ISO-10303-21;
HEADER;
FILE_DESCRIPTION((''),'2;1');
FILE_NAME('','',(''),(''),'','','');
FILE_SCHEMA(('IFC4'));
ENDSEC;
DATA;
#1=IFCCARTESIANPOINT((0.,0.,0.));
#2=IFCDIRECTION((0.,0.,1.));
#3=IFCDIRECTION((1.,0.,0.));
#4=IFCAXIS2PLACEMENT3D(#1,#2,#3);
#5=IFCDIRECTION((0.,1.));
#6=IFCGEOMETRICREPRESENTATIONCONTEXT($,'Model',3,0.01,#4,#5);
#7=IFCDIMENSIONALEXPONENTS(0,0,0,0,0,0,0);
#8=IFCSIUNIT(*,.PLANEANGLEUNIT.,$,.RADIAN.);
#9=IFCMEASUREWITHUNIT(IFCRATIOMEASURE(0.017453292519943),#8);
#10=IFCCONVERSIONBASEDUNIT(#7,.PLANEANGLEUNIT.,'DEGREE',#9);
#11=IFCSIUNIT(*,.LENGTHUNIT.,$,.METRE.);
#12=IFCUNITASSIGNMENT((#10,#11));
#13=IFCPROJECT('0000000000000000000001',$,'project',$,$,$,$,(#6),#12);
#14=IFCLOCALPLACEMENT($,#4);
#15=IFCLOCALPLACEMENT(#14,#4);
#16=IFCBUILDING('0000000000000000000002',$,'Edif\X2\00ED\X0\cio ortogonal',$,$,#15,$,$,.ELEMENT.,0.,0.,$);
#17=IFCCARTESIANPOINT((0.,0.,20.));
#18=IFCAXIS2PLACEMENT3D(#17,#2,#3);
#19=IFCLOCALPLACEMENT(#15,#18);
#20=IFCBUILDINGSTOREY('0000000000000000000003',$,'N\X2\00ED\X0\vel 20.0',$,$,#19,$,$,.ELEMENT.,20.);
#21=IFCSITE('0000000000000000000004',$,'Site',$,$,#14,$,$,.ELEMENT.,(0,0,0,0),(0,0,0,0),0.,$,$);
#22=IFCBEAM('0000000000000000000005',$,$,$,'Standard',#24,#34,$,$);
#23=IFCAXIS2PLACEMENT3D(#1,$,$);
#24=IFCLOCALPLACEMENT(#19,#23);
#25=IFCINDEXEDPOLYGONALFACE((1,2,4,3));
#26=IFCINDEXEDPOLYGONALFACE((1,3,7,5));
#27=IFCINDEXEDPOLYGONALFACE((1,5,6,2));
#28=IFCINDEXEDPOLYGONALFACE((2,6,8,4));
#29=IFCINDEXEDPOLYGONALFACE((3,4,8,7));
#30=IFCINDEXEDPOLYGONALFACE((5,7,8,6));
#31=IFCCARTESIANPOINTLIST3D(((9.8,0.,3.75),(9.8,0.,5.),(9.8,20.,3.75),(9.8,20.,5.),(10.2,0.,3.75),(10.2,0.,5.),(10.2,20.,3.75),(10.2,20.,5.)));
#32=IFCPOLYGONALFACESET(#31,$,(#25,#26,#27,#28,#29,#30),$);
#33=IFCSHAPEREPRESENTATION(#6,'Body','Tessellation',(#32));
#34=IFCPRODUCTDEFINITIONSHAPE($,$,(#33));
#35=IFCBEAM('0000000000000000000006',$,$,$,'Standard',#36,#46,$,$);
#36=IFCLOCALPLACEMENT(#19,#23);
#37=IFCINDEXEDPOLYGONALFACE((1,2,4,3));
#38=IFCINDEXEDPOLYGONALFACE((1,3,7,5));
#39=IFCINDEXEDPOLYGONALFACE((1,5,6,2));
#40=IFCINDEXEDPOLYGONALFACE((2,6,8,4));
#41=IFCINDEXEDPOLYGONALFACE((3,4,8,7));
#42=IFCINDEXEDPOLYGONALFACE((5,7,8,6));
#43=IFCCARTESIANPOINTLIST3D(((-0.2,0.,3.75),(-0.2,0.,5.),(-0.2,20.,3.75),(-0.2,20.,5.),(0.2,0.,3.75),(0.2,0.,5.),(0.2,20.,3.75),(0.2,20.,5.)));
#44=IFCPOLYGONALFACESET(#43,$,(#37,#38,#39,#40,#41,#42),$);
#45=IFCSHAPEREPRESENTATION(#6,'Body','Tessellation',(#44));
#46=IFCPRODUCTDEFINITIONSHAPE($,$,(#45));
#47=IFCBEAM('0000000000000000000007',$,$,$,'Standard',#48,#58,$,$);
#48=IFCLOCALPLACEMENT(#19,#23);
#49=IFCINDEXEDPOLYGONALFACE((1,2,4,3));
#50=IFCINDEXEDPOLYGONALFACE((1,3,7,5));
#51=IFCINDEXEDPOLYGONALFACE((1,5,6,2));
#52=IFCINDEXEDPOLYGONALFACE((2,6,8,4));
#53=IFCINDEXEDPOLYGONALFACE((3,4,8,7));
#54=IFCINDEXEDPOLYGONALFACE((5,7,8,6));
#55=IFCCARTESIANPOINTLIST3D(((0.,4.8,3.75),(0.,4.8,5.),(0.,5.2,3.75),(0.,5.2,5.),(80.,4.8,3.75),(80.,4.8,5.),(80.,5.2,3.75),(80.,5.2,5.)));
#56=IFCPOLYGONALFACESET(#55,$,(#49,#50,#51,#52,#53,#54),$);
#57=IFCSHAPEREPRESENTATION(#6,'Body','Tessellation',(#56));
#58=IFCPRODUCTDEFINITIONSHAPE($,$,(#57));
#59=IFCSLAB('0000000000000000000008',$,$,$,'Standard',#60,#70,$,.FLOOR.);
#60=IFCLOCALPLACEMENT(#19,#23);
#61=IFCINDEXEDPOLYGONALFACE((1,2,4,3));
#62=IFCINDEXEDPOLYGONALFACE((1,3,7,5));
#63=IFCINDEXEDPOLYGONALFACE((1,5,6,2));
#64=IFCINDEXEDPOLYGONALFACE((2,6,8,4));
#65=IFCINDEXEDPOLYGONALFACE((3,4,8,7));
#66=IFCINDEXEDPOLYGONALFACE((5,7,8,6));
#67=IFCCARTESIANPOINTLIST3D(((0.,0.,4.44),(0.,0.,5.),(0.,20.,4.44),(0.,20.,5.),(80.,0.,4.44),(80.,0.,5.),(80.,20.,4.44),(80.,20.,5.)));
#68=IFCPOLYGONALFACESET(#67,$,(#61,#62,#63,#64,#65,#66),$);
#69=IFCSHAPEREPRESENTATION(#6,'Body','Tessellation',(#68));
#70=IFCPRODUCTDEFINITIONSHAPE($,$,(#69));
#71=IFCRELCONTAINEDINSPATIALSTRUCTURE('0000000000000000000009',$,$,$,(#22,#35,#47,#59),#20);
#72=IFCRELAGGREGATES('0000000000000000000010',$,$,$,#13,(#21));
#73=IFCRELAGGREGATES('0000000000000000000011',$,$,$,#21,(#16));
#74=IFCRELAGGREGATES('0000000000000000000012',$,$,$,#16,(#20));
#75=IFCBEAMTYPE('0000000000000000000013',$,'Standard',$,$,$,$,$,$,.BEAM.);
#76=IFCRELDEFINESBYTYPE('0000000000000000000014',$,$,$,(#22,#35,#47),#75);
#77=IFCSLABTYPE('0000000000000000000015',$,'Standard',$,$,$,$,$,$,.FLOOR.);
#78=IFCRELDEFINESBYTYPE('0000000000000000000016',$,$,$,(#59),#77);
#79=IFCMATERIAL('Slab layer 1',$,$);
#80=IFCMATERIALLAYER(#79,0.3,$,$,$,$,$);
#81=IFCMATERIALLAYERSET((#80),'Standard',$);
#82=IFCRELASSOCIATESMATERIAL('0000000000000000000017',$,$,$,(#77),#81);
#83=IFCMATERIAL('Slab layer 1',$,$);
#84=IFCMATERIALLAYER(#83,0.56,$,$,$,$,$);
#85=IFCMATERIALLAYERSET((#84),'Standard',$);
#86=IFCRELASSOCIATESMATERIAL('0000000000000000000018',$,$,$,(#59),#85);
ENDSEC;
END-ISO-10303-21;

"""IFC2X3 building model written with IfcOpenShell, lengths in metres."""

from ifc_helpers import new_model, entity, si_unit, converted_unit, direction, frame, origin_with_axes, origin_2d, place, context, project, spatial, polyline, rectangle, outline, extrude, material, layer, layer_set, layer_usage, type_object, element, save


model = new_model("IFC2X3")

# Units and contexts
model_context = context("Model", 3, precision=0.01, world=origin_with_axes(), true_north=direction((0.0, 1.0)))
ifc_project = project(units=[converted_unit("PLANEANGLEUNIT", "DEGREE", entity("IfcRatioMeasure", 0.017453292519943), si_unit("PLANEANGLEUNIT", "RADIAN"), dimensions=[0, 0, 0, 0, 0, 0, 0]), si_unit("LENGTHUNIT", "METRE")], contexts=[model_context])

# Site, building, storey
site_placement = place(None, origin_with_axes())
site = spatial("IfcSite", under=ifc_project, at=site_placement, Name="Site", CompositionType="ELEMENT", RefLatitude=(0, 0, 0, 0), RefLongitude=(0, 0, 0, 0), RefElevation=0.0)
building_placement = place(site_placement, origin_with_axes())
building = spatial("IfcBuilding", under=site, at=building_placement, Name="Edifício ortogonal", CompositionType="ELEMENT", ElevationOfRefHeight=0.0, ElevationOfTerrain=0.0)
storey_placement = place(building_placement, frame((0.0, 0.0, 20.0), z_axis=(0.0, 0.0, 1.0), x_axis=(1.0, 0.0, 0.0)))
storey = spatial("IfcBuildingStorey", under=building, at=storey_placement, Name="Nível 20.0", CompositionType="ELEMENT", Elevation=20.0)

# Beams
beam_type = type_object("IfcBeamType", Name="Standard", PredefinedType="BEAM")
for number, where, z_axis, x_axis in (
    (1, (10.0, 20.0, 25.0), (0.0, 0.0, 1.0), (0.0, -1.0, 0.0)),
    (2, (0.0, 20.0, 25.0), (0.0, 0.0, 1.0), (0.0, -1.0, 0.0)),
):
    element("IfcBeam", number, at=place(site_placement, frame(where, z_axis=z_axis, x_axis=x_axis)), inside=storey, type_object=beam_type, ObjectType="Standard", context=model_context, shape_type="SweptSolid", body=[
        extrude(rectangle(XDim=0.4, YDim=1.25, at=origin_2d()), frame((0.0, 0.0, -0.625), z_axis=(1.0, 0.0, 0.0), x_axis=(0.0, 1.0, 0.0)), (0.0, 0.0, 1.0), 20.0),
    ])
beam_placement = place(site_placement, frame((0.0, 5.0, 25.0), z_axis=(0.0, 0.0, 1.0), x_axis=(1.0, 0.0, 0.0)))
element("IfcBeam", 3, at=beam_placement, inside=storey, type_object=beam_type, ObjectType="Standard", context=model_context, shape_type="SweptSolid", body=[
    extrude(rectangle(XDim=0.4, YDim=1.25, at=origin_2d()), frame((0.0, 0.0, -0.625), z_axis=(1.0, 0.0, 0.0), x_axis=(0.0, 1.0, 0.0)), (0.0, 0.0, 1.0), 80.0),
])

# Slab
ifc_material_1 = material(Name="Slab layer 1")
ifc_layer_1 = layer(ifc_material_1, 0.56)
ifc_layer_set_1 = layer_set([ifc_layer_1], Name="Standard")
ifc_layer_usage = layer_usage(ifc_layer_set_1, "AXIS3", "POSITIVE", 0.0)
ifc_material_2 = material(Name="Slab layer 1")
ifc_layer_2 = layer(ifc_material_2, 0.3)
ifc_layer_set_2 = layer_set([ifc_layer_2], Name="Standard")
slab_type = type_object("IfcSlabType", Name="Standard", PredefinedType="FLOOR", material=ifc_layer_set_2)
slab_placement = place(site_placement, frame((0.0, 0.0, 25.0), z_axis=(0.0, 0.0, 1.0), x_axis=(1.0, 0.0, 0.0)))
element("IfcSlab", 4, at=slab_placement, inside=storey, type_object=slab_type, material=ifc_layer_usage, ObjectType="Standard", PredefinedType="FLOOR", context=model_context, shape_type="SweptSolid", body=[
    extrude(outline(polyline([(0.0, 0.0), (80.0, 0.0), (80.0, 20.0), (0.0, 20.0), (0.0, 0.0)])), frame((0.0, 0.0, -0.56), z_axis=(0.0, 0.0, 1.0), x_axis=(1.0, 0.0, 0.0)), (0.0, 0.0, 1.0), 0.56),
])

save(model, "model.ifc")
